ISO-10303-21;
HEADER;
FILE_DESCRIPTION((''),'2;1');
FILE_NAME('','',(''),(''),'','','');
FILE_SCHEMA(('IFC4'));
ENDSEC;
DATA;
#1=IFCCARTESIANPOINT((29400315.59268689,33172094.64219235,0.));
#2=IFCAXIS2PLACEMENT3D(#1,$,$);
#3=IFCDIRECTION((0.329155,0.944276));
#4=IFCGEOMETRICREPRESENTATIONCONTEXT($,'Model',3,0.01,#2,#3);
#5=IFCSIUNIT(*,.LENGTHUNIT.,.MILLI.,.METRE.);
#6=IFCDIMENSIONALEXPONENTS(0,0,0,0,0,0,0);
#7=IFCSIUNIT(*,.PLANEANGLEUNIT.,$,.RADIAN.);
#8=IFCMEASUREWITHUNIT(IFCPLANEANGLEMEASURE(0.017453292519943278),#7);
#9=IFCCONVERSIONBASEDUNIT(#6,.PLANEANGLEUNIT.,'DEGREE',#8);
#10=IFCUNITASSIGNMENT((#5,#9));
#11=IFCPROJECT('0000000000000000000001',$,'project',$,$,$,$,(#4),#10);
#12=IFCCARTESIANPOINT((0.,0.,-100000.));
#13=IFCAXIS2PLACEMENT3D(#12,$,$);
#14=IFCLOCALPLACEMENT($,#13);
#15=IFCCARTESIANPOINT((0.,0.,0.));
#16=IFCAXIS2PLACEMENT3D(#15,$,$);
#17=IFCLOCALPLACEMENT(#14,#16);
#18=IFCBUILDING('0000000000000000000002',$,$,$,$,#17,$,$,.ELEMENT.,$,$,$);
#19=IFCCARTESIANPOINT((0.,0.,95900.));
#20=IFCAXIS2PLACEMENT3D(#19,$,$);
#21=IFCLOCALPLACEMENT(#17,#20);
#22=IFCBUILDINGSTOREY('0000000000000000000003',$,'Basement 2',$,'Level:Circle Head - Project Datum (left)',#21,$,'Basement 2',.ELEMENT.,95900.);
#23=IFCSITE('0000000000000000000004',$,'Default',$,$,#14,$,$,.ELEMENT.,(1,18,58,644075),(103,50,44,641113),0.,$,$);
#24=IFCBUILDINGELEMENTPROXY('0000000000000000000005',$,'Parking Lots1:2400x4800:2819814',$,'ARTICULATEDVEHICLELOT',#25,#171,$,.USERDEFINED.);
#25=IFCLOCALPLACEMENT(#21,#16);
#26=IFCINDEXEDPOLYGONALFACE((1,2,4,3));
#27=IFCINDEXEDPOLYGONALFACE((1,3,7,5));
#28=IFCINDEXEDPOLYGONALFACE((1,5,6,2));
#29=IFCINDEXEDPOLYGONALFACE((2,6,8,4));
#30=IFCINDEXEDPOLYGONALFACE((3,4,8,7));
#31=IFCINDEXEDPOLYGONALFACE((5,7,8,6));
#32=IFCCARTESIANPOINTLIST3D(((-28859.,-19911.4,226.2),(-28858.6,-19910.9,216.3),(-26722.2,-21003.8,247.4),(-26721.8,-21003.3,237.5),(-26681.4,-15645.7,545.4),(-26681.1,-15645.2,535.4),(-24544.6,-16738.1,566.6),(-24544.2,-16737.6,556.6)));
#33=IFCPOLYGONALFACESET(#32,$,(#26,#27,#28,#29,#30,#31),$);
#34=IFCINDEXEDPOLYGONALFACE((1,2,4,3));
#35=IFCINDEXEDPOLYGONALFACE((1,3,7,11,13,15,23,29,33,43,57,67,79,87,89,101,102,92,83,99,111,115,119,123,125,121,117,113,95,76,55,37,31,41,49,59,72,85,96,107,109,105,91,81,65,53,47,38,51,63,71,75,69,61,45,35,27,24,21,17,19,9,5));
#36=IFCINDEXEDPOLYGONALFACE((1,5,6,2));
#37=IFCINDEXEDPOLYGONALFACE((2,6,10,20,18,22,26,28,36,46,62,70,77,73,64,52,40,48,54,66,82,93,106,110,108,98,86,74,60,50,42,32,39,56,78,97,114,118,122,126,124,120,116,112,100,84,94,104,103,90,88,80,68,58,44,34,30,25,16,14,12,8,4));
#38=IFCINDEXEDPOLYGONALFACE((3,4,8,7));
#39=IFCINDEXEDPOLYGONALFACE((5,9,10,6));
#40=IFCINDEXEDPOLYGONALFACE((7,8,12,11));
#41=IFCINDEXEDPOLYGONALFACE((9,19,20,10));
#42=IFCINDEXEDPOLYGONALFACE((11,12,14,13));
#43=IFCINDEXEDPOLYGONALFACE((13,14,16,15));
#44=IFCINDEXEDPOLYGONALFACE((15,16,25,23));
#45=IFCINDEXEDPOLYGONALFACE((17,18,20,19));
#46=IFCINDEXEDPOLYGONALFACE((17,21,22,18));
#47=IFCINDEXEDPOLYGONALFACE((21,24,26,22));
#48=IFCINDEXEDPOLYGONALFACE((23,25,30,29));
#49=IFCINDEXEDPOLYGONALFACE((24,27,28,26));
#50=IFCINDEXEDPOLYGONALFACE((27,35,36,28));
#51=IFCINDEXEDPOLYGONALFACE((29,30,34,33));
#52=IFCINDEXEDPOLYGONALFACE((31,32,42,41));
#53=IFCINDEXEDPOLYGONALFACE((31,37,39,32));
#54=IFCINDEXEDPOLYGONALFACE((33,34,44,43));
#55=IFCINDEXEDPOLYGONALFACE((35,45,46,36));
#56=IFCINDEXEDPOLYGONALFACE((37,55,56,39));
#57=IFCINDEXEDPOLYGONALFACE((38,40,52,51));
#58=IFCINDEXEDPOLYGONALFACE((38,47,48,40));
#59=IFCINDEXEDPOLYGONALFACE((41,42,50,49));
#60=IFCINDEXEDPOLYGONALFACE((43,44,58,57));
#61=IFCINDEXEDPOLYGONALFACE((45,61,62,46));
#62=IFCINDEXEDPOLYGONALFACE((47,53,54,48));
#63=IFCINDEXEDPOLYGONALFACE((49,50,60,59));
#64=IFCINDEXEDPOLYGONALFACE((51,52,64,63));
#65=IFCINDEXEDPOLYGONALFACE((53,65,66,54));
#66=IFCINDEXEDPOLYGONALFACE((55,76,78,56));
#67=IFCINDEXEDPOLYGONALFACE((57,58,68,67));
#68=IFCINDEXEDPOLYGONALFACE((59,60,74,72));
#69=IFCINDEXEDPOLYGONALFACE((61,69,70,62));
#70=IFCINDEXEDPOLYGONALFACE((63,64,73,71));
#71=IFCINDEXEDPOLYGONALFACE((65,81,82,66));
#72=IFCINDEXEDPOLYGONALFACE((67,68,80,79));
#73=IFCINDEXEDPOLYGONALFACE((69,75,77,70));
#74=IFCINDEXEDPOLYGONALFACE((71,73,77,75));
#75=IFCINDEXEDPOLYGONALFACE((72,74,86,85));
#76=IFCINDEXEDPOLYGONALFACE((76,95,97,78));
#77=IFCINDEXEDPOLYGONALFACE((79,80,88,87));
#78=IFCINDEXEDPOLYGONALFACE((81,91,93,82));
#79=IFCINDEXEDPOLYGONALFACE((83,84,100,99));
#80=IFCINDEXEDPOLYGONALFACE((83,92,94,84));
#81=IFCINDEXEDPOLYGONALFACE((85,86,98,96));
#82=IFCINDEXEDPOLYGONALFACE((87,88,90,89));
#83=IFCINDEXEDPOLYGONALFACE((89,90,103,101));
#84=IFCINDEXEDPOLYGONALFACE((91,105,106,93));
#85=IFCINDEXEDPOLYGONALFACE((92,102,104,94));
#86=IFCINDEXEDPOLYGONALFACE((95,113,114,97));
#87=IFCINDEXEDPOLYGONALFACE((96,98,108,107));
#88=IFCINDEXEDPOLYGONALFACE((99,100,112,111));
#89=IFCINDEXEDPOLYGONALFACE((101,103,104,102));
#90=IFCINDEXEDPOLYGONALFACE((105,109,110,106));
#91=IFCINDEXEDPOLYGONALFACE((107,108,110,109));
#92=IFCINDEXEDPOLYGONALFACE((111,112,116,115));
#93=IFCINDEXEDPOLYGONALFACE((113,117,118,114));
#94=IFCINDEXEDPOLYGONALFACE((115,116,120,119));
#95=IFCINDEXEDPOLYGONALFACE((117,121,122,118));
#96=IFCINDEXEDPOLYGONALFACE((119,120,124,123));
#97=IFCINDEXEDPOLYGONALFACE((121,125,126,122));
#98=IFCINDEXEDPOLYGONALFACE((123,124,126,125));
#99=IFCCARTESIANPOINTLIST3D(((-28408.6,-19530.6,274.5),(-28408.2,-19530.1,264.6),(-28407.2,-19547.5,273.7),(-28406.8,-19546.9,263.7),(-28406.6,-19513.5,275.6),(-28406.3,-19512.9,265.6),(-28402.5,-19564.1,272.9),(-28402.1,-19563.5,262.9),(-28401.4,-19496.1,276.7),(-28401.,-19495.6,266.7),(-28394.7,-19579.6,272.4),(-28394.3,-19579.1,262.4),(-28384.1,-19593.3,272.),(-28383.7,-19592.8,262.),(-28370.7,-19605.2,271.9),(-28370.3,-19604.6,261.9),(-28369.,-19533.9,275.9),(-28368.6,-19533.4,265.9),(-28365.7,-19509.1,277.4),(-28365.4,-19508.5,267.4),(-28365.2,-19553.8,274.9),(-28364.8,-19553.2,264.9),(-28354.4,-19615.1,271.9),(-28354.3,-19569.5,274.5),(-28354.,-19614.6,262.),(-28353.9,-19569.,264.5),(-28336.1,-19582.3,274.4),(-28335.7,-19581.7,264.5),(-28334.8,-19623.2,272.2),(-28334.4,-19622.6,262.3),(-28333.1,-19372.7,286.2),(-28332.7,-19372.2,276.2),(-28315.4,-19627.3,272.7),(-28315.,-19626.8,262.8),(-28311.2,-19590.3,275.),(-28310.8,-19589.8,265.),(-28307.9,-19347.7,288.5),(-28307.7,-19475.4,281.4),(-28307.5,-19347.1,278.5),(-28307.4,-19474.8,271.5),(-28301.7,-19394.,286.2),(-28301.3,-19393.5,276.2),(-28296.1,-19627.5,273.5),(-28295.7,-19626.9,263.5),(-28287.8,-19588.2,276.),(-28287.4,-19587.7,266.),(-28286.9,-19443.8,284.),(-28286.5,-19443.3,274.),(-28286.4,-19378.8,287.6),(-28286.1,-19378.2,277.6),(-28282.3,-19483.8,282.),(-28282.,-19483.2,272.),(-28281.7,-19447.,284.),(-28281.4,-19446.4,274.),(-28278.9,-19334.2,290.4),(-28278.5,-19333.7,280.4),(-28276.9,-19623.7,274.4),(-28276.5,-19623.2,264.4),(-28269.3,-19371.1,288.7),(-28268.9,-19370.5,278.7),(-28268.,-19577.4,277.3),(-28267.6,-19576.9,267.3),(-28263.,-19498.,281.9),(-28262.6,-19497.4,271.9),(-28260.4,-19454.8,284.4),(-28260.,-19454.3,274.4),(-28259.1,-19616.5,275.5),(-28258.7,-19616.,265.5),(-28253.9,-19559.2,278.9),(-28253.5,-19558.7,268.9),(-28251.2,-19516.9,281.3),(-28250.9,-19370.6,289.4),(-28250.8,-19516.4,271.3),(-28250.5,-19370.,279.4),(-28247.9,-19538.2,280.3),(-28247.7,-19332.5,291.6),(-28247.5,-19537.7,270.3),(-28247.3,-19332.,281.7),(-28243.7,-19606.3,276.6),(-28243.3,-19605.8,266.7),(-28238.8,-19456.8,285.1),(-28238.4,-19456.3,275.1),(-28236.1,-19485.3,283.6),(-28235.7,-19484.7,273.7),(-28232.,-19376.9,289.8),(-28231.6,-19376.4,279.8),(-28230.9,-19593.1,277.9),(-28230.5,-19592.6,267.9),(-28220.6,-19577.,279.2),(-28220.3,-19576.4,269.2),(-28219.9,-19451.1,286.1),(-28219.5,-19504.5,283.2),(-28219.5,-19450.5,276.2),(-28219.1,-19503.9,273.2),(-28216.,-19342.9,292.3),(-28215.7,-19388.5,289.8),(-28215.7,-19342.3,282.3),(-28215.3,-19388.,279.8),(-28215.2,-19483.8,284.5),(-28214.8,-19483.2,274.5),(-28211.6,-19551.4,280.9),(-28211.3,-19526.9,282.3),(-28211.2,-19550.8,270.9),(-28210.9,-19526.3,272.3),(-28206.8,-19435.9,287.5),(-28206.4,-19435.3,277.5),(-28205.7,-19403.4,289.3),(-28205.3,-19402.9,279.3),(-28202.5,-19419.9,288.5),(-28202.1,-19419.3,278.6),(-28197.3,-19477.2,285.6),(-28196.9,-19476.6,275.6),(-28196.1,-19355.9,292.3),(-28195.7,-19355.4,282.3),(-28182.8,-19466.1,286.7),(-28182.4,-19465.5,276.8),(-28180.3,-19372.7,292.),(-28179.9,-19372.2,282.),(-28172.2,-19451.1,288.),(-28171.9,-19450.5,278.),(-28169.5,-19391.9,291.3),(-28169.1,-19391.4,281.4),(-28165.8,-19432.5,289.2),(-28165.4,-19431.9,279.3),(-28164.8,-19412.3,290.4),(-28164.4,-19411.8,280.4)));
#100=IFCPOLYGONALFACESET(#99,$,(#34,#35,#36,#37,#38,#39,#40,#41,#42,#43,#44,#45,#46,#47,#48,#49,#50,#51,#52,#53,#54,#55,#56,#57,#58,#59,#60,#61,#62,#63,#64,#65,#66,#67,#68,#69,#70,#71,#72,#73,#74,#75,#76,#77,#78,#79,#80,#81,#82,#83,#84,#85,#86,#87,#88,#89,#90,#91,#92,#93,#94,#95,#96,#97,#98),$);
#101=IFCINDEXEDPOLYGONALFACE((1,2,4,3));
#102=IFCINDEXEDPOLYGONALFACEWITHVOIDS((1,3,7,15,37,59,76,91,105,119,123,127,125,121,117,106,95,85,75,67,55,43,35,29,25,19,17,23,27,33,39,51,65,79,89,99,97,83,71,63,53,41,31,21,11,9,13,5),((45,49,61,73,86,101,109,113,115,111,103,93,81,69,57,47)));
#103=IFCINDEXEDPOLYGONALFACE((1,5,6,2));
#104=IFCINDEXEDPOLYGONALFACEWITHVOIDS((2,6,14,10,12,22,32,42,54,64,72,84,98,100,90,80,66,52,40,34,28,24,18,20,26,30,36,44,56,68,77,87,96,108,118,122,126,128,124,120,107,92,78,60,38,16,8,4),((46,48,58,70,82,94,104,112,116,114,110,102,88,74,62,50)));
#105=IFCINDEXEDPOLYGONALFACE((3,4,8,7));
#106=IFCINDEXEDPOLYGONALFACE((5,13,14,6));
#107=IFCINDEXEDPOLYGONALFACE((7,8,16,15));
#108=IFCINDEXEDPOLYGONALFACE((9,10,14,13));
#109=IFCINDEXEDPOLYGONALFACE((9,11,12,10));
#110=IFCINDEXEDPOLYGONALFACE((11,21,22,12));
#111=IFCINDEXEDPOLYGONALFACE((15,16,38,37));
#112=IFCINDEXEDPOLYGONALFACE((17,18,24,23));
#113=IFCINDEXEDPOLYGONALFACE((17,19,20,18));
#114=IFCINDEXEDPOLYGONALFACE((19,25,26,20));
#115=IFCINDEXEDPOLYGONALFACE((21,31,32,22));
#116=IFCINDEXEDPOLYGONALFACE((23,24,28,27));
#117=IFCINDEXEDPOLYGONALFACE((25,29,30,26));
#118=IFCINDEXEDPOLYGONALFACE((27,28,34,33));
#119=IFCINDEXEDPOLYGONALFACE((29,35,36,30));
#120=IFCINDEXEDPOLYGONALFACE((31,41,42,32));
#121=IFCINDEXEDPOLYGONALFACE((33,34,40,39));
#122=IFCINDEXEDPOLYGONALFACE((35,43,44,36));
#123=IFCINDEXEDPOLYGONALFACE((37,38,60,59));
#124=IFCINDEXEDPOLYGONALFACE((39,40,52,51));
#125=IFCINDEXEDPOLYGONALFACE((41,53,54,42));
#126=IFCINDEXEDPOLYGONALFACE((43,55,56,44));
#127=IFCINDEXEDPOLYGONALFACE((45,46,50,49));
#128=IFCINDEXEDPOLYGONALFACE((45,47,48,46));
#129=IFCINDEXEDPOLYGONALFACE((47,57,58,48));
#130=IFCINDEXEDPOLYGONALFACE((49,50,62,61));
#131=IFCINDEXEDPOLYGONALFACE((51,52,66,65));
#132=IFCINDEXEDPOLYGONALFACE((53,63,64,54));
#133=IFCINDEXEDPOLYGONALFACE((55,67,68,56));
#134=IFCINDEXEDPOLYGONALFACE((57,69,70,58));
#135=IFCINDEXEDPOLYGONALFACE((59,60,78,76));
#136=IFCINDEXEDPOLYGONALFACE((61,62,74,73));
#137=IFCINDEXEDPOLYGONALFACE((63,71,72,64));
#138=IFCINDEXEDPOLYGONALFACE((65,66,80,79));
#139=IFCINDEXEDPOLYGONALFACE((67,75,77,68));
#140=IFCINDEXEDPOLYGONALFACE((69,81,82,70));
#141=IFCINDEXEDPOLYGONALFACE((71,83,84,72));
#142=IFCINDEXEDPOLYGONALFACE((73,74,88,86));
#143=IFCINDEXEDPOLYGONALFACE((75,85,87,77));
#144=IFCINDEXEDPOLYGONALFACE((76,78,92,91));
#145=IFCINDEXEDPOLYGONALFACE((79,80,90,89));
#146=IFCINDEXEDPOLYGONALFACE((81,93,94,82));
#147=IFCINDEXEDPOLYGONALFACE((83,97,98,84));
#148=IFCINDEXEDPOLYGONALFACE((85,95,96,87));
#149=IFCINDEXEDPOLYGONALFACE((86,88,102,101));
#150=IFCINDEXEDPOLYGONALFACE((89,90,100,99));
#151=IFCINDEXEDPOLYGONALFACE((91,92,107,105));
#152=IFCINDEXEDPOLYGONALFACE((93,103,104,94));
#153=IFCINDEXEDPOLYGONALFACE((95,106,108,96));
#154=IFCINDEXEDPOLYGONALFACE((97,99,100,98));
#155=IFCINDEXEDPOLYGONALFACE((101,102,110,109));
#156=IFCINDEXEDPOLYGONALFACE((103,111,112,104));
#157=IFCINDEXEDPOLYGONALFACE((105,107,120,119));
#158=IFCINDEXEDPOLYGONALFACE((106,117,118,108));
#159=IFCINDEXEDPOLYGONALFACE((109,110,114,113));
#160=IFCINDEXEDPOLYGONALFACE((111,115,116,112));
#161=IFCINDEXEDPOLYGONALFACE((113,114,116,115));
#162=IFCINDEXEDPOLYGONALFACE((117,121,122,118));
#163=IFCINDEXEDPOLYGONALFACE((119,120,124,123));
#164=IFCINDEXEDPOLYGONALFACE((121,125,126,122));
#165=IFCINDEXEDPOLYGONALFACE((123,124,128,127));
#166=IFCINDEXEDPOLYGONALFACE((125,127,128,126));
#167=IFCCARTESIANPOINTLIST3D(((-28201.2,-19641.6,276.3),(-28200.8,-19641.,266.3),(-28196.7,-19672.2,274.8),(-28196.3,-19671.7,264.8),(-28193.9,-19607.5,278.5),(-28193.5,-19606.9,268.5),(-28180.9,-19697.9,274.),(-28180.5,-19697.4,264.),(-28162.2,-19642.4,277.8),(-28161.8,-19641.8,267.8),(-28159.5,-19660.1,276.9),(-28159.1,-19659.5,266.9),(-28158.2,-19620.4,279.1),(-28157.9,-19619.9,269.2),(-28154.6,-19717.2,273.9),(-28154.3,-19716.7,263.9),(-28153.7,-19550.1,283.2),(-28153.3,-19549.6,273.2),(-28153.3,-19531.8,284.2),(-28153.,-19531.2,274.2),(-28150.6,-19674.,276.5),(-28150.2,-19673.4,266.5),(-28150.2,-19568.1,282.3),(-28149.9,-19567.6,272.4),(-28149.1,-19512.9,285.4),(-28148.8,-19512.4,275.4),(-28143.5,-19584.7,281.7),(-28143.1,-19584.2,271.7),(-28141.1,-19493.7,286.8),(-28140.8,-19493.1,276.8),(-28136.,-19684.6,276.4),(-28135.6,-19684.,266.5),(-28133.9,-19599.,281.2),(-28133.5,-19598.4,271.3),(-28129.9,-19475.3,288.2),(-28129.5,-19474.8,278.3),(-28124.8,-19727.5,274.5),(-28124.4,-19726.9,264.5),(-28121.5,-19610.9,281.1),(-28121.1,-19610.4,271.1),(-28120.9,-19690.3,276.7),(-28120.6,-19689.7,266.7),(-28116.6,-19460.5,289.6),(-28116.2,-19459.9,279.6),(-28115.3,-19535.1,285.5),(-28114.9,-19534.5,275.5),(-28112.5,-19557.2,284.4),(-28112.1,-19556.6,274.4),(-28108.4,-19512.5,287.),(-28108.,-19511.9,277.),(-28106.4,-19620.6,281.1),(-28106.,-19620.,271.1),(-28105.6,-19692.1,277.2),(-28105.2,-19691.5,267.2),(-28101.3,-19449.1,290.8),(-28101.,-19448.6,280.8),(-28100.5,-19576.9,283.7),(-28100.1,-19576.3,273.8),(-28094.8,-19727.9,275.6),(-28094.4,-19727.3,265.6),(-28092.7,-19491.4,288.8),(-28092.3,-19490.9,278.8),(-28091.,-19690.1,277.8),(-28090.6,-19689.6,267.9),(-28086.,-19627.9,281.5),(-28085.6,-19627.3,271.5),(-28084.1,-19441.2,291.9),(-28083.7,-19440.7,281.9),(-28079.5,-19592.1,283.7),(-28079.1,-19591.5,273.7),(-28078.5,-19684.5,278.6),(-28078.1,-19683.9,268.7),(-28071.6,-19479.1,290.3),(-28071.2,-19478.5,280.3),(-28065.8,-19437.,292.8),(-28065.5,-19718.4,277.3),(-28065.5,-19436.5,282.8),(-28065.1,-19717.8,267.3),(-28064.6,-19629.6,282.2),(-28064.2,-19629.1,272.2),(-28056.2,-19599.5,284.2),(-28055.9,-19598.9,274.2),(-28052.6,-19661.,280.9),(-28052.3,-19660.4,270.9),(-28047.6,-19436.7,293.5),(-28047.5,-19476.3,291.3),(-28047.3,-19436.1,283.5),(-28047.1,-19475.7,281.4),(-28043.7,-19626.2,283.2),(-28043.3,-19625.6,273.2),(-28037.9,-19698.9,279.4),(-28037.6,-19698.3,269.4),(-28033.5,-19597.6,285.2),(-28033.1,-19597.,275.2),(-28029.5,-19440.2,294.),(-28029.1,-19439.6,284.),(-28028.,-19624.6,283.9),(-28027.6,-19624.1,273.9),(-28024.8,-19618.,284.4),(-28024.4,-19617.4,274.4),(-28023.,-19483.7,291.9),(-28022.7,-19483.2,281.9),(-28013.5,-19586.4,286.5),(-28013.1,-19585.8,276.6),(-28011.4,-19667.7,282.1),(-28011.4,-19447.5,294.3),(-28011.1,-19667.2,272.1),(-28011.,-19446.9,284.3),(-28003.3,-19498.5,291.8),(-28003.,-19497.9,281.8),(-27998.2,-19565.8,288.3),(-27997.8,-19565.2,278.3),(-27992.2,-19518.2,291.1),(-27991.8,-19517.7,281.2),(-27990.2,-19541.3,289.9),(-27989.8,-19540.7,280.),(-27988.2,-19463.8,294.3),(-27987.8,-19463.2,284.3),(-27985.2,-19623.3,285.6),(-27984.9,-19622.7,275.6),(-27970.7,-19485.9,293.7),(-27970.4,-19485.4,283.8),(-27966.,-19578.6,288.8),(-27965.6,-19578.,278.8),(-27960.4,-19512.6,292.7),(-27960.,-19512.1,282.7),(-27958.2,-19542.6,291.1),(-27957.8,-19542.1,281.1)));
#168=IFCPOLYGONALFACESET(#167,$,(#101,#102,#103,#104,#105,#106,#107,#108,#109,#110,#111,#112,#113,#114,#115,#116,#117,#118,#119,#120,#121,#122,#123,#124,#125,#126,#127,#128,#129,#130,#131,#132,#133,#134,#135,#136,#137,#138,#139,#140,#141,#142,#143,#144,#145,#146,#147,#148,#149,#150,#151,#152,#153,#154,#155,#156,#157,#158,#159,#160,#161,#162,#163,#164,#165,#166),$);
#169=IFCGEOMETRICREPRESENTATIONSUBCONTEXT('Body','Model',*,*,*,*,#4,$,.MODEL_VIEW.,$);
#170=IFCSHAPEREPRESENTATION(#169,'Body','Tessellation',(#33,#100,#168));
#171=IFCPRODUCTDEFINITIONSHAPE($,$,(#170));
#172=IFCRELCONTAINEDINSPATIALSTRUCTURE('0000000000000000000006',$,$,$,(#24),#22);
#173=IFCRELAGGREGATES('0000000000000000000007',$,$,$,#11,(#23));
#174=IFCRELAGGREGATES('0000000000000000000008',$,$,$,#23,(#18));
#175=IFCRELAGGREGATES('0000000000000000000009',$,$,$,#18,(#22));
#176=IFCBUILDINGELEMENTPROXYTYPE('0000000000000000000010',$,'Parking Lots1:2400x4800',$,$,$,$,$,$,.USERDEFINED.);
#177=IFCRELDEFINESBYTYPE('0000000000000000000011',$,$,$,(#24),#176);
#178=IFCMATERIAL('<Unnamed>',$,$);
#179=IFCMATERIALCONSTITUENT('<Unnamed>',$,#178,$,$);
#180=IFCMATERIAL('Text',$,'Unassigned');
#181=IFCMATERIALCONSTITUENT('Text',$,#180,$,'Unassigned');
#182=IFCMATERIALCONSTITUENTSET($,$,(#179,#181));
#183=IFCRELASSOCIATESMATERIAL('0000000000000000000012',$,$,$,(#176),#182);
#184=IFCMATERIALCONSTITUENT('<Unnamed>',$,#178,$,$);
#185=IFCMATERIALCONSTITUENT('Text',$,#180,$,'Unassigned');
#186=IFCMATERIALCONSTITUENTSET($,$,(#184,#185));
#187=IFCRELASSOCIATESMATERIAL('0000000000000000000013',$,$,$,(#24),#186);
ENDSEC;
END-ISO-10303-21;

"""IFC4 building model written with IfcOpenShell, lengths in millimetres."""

from ifc_helpers import new_model, entity, si_unit, converted_unit, direction, frame, origin, place, context, subcontext, project, spatial, indexed_curve, outline, extrude, source, transform, mapped, material, constituent, constituent_set, type_object, type_shapes, element, save


model = new_model("IFC4")

# Units and contexts
model_context = context("Model", 3, precision=0.01, world=frame((29400315.59268689, 33172094.64219235, 0.0)), true_north=direction((0.329155, 0.944276)))
body_context = subcontext(model_context, "Body", "Model", "MODEL_VIEW")
ifc_project = project(units=[si_unit("LENGTHUNIT", "METRE", prefix="MILLI"), converted_unit("PLANEANGLEUNIT", "DEGREE", entity("IfcPlaneAngleMeasure", 0.017453292519943278), si_unit("PLANEANGLEUNIT", "RADIAN"), dimensions=[0, 0, 0, 0, 0, 0, 0])], contexts=[model_context])

# Site, building, storey
site_placement = place(None, frame((0.0, 0.0, -100000.0)))
site = spatial("IfcSite", under=ifc_project, at=site_placement, Name="Default", CompositionType="ELEMENT", RefLatitude=(1, 18, 58, 644075), RefLongitude=(103, 50, 44, 641113), RefElevation=0.0)
building_placement = place(site_placement, origin())
building = spatial("IfcBuilding", under=site, at=building_placement, CompositionType="ELEMENT")
storey_placement = place(building_placement, frame((0.0, 0.0, 95900.0)))
storey = spatial("IfcBuildingStorey", under=building, at=storey_placement, Name="Basement 2", ObjectType="Level:Circle Head - Project Datum (left)", LongName="Basement 2", CompositionType="ELEMENT", Elevation=95900.0)

# Shared definitions
ifc_material_1 = material(Name="<Unnamed>")

# Building element proxy
ifc_material_2 = material(Name="Text", Category="Unassigned")
ifc_constituent_1 = constituent(ifc_material_1, Name="<Unnamed>")
ifc_constituent_2 = constituent(ifc_material_2, Name="Text", Category="Unassigned")
ifc_constituent_set_1 = constituent_set(constituents=[ifc_constituent_1, ifc_constituent_2])
ifc_constituent_3 = constituent(ifc_material_1, Name="<Unnamed>")
ifc_constituent_4 = constituent(ifc_material_2, Name="Text", Category="Unassigned")
ifc_constituent_set_2 = constituent_set(constituents=[ifc_constituent_3, ifc_constituent_4])
building_element_proxy_type_1 = type_object("IfcBuildingElementProxyType", Name="Parking Lots1:2400x4800", PredefinedType="USERDEFINED", material=ifc_constituent_set_2)
shared_shape_1 = source(origin(), body_context, "Body", "SweptSolid", [
    extrude(outline(indexed_curve([(-1200.0, -2400.0), (1200.0, -2400.0), (1200.0, 2400.0), (-1200.0, 2400.0), (-1200.0, -2400.0)], self_intersect=False)), frame((1200.0, -2400.0, 0.0), z_axis=(0.0, 0.0, 1.0), x_axis=(-1.0, 0.0, 0.0)), (0.0, 0.0, 1.0), 10.0),
    extrude(outline(indexed_curve([(41.2, -119.5), (59.4, -119.5), (76.4, -116.4), (92.1, -110.3), (106.7, -101.0), (119.4, -89.1), (129.4, -75.0), (136.9, -58.7), (141.8, -40.2), (143.8, -19.2), (142.2, 0.6), (136.7, 19.2), (127.6, 36.5), (115.5, 51.5), (101.3, 63.2), (84.9, 71.7), (66.4, 76.9), (39.2, 78.2), (15.6, 71.5), (-3.5, 57.2), (-17.0, 35.7), (-24.5, 55.3), (-36.1, 70.5), (-50.9, 81.2), (-68.4, 87.0), (-88.1, 87.8), (-107.7, 83.0), (-125.9, 72.6), (-141.2, 56.8), (-152.7, 36.8), (-159.5, 13.9), (-160.2, -19.4), (-149.6, -48.7), (-128.2, -72.7), (-96.9, -89.6), (-85.6, -53.4), (-104.7, -43.2), (-117.0, -28.9), (-122.8, -11.5), (-122.2, 8.5), (-115.8, 27.4), (-104.4, 41.3), (-89.5, 49.1), (-72.9, 49.6), (-54.6, 41.4), (-43.6, 24.9), (-39.2, 3.6), (-40.6, -19.0), (-42.1, -24.9), (-5.8, -35.8), (-5.1, -9.0), (2.9, 13.6), (17.7, 30.3), (37.1, 39.7), (59.0, 40.0), (80.6, 31.7), (96.7, 15.8), (105.4, -6.0), (104.9, -32.2), (98.0, -53.3), (86.0, -68.3), (68.1, -77.6), (43.3, -81.6), (41.2, -119.5)], self_intersect=False)), frame((329.1, -4158.0, 10.0), z_axis=(0.0, 0.0, 1.0), x_axis=(0.178774, -0.98389, 0.0)), (0.0, 0.0, 1.0), 10.0),
    extrude(outline(indexed_curve([(33.6, -97.6), (68.6, -97.6), (97.6, -86.8), (119.5, -66.0), (132.9, -36.3), (136.6, -5.0), (130.7, 24.5), (115.2, 51.2), (90.3, 74.0), (54.2, 93.5), (5.1, 109.8), (-42.7, 119.3), (-79.6, 119.4), (-108.5, 111.1), (-132.5, 95.3), (-150.5, 73.7), (-161.5, 47.5), (-164.9, 28.3), (-164.5, 9.8), (-160.3, -7.9), (-152.3, -24.9), (-141.0, -40.1), (-126.6, -52.7), (-109.3, -62.6), (-88.9, -69.7), (-68.4, -73.6), (-49.1, -73.7), (-31.0, -70.3), (-14.1, -63.1), (0.7, -53.0), (12.7, -40.7), (21.8, -26.1), (28.0, -9.2), (30.9, 12.2), (28.1, 33.5), (20.3, 53.3), (8.3, 70.0), (15.4, 68.3), (56.3, 51.8), (84.7, 31.4), (92.9, 20.3), (97.9, 6.5), (99.3, -9.0), (96.9, -24.9), (89.6, -41.3), (77.9, -53.0), (61.1, -59.3), (38.8, -60.0), (33.6, -97.6)], self_intersect=False), holes=[indexed_curve([(-48.4, 85.2), (-25.1, 74.5), (-9.9, 57.2), (-3.2, 35.4), (-5.6, 11.1), (-16.1, -12.6), (-32.8, -28.5), (-53.9, -35.8), (-77.4, -33.8), (-101.4, -22.9), (-117.9, -4.7), (-125.7, 18.2), (-123.6, 43.7), (-113.3, 66.1), (-96.3, 81.1), (-74.2, 87.8), (-48.4, 85.2)], self_intersect=False)]), frame((539.9, -4167.0, 10.0), z_axis=(0.0, 0.0, 1.0), x_axis=(0.258285, -0.966069, 0.0)), (0.0, 0.0, 1.0), 10.0),
])
type_shapes(building_element_proxy_type_1, [shared_shape_1])
proxy_1_placement = place(storey_placement, frame((-26681.1, -15645.2, 535.4), z_axis=(-0.038113, -0.055189, 0.997748), x_axis=(0.890359, -0.455173, 0.008834)))
element("IfcBuildingElementProxy", 1, at=proxy_1_placement, inside=storey, type_object=building_element_proxy_type_1, material=ifc_constituent_set_1, Name="Parking Lots1:2400x4800:2819814", ObjectType="ARTICULATEDVEHICLELOT", PredefinedType="USERDEFINED", context=body_context, shape_type="MappedRepresentation", body=[
    mapped(shared_shape_1, transform((0.0, 0.0, 0.0), scale=1.0)),
])

save(model, "model.ifc")
